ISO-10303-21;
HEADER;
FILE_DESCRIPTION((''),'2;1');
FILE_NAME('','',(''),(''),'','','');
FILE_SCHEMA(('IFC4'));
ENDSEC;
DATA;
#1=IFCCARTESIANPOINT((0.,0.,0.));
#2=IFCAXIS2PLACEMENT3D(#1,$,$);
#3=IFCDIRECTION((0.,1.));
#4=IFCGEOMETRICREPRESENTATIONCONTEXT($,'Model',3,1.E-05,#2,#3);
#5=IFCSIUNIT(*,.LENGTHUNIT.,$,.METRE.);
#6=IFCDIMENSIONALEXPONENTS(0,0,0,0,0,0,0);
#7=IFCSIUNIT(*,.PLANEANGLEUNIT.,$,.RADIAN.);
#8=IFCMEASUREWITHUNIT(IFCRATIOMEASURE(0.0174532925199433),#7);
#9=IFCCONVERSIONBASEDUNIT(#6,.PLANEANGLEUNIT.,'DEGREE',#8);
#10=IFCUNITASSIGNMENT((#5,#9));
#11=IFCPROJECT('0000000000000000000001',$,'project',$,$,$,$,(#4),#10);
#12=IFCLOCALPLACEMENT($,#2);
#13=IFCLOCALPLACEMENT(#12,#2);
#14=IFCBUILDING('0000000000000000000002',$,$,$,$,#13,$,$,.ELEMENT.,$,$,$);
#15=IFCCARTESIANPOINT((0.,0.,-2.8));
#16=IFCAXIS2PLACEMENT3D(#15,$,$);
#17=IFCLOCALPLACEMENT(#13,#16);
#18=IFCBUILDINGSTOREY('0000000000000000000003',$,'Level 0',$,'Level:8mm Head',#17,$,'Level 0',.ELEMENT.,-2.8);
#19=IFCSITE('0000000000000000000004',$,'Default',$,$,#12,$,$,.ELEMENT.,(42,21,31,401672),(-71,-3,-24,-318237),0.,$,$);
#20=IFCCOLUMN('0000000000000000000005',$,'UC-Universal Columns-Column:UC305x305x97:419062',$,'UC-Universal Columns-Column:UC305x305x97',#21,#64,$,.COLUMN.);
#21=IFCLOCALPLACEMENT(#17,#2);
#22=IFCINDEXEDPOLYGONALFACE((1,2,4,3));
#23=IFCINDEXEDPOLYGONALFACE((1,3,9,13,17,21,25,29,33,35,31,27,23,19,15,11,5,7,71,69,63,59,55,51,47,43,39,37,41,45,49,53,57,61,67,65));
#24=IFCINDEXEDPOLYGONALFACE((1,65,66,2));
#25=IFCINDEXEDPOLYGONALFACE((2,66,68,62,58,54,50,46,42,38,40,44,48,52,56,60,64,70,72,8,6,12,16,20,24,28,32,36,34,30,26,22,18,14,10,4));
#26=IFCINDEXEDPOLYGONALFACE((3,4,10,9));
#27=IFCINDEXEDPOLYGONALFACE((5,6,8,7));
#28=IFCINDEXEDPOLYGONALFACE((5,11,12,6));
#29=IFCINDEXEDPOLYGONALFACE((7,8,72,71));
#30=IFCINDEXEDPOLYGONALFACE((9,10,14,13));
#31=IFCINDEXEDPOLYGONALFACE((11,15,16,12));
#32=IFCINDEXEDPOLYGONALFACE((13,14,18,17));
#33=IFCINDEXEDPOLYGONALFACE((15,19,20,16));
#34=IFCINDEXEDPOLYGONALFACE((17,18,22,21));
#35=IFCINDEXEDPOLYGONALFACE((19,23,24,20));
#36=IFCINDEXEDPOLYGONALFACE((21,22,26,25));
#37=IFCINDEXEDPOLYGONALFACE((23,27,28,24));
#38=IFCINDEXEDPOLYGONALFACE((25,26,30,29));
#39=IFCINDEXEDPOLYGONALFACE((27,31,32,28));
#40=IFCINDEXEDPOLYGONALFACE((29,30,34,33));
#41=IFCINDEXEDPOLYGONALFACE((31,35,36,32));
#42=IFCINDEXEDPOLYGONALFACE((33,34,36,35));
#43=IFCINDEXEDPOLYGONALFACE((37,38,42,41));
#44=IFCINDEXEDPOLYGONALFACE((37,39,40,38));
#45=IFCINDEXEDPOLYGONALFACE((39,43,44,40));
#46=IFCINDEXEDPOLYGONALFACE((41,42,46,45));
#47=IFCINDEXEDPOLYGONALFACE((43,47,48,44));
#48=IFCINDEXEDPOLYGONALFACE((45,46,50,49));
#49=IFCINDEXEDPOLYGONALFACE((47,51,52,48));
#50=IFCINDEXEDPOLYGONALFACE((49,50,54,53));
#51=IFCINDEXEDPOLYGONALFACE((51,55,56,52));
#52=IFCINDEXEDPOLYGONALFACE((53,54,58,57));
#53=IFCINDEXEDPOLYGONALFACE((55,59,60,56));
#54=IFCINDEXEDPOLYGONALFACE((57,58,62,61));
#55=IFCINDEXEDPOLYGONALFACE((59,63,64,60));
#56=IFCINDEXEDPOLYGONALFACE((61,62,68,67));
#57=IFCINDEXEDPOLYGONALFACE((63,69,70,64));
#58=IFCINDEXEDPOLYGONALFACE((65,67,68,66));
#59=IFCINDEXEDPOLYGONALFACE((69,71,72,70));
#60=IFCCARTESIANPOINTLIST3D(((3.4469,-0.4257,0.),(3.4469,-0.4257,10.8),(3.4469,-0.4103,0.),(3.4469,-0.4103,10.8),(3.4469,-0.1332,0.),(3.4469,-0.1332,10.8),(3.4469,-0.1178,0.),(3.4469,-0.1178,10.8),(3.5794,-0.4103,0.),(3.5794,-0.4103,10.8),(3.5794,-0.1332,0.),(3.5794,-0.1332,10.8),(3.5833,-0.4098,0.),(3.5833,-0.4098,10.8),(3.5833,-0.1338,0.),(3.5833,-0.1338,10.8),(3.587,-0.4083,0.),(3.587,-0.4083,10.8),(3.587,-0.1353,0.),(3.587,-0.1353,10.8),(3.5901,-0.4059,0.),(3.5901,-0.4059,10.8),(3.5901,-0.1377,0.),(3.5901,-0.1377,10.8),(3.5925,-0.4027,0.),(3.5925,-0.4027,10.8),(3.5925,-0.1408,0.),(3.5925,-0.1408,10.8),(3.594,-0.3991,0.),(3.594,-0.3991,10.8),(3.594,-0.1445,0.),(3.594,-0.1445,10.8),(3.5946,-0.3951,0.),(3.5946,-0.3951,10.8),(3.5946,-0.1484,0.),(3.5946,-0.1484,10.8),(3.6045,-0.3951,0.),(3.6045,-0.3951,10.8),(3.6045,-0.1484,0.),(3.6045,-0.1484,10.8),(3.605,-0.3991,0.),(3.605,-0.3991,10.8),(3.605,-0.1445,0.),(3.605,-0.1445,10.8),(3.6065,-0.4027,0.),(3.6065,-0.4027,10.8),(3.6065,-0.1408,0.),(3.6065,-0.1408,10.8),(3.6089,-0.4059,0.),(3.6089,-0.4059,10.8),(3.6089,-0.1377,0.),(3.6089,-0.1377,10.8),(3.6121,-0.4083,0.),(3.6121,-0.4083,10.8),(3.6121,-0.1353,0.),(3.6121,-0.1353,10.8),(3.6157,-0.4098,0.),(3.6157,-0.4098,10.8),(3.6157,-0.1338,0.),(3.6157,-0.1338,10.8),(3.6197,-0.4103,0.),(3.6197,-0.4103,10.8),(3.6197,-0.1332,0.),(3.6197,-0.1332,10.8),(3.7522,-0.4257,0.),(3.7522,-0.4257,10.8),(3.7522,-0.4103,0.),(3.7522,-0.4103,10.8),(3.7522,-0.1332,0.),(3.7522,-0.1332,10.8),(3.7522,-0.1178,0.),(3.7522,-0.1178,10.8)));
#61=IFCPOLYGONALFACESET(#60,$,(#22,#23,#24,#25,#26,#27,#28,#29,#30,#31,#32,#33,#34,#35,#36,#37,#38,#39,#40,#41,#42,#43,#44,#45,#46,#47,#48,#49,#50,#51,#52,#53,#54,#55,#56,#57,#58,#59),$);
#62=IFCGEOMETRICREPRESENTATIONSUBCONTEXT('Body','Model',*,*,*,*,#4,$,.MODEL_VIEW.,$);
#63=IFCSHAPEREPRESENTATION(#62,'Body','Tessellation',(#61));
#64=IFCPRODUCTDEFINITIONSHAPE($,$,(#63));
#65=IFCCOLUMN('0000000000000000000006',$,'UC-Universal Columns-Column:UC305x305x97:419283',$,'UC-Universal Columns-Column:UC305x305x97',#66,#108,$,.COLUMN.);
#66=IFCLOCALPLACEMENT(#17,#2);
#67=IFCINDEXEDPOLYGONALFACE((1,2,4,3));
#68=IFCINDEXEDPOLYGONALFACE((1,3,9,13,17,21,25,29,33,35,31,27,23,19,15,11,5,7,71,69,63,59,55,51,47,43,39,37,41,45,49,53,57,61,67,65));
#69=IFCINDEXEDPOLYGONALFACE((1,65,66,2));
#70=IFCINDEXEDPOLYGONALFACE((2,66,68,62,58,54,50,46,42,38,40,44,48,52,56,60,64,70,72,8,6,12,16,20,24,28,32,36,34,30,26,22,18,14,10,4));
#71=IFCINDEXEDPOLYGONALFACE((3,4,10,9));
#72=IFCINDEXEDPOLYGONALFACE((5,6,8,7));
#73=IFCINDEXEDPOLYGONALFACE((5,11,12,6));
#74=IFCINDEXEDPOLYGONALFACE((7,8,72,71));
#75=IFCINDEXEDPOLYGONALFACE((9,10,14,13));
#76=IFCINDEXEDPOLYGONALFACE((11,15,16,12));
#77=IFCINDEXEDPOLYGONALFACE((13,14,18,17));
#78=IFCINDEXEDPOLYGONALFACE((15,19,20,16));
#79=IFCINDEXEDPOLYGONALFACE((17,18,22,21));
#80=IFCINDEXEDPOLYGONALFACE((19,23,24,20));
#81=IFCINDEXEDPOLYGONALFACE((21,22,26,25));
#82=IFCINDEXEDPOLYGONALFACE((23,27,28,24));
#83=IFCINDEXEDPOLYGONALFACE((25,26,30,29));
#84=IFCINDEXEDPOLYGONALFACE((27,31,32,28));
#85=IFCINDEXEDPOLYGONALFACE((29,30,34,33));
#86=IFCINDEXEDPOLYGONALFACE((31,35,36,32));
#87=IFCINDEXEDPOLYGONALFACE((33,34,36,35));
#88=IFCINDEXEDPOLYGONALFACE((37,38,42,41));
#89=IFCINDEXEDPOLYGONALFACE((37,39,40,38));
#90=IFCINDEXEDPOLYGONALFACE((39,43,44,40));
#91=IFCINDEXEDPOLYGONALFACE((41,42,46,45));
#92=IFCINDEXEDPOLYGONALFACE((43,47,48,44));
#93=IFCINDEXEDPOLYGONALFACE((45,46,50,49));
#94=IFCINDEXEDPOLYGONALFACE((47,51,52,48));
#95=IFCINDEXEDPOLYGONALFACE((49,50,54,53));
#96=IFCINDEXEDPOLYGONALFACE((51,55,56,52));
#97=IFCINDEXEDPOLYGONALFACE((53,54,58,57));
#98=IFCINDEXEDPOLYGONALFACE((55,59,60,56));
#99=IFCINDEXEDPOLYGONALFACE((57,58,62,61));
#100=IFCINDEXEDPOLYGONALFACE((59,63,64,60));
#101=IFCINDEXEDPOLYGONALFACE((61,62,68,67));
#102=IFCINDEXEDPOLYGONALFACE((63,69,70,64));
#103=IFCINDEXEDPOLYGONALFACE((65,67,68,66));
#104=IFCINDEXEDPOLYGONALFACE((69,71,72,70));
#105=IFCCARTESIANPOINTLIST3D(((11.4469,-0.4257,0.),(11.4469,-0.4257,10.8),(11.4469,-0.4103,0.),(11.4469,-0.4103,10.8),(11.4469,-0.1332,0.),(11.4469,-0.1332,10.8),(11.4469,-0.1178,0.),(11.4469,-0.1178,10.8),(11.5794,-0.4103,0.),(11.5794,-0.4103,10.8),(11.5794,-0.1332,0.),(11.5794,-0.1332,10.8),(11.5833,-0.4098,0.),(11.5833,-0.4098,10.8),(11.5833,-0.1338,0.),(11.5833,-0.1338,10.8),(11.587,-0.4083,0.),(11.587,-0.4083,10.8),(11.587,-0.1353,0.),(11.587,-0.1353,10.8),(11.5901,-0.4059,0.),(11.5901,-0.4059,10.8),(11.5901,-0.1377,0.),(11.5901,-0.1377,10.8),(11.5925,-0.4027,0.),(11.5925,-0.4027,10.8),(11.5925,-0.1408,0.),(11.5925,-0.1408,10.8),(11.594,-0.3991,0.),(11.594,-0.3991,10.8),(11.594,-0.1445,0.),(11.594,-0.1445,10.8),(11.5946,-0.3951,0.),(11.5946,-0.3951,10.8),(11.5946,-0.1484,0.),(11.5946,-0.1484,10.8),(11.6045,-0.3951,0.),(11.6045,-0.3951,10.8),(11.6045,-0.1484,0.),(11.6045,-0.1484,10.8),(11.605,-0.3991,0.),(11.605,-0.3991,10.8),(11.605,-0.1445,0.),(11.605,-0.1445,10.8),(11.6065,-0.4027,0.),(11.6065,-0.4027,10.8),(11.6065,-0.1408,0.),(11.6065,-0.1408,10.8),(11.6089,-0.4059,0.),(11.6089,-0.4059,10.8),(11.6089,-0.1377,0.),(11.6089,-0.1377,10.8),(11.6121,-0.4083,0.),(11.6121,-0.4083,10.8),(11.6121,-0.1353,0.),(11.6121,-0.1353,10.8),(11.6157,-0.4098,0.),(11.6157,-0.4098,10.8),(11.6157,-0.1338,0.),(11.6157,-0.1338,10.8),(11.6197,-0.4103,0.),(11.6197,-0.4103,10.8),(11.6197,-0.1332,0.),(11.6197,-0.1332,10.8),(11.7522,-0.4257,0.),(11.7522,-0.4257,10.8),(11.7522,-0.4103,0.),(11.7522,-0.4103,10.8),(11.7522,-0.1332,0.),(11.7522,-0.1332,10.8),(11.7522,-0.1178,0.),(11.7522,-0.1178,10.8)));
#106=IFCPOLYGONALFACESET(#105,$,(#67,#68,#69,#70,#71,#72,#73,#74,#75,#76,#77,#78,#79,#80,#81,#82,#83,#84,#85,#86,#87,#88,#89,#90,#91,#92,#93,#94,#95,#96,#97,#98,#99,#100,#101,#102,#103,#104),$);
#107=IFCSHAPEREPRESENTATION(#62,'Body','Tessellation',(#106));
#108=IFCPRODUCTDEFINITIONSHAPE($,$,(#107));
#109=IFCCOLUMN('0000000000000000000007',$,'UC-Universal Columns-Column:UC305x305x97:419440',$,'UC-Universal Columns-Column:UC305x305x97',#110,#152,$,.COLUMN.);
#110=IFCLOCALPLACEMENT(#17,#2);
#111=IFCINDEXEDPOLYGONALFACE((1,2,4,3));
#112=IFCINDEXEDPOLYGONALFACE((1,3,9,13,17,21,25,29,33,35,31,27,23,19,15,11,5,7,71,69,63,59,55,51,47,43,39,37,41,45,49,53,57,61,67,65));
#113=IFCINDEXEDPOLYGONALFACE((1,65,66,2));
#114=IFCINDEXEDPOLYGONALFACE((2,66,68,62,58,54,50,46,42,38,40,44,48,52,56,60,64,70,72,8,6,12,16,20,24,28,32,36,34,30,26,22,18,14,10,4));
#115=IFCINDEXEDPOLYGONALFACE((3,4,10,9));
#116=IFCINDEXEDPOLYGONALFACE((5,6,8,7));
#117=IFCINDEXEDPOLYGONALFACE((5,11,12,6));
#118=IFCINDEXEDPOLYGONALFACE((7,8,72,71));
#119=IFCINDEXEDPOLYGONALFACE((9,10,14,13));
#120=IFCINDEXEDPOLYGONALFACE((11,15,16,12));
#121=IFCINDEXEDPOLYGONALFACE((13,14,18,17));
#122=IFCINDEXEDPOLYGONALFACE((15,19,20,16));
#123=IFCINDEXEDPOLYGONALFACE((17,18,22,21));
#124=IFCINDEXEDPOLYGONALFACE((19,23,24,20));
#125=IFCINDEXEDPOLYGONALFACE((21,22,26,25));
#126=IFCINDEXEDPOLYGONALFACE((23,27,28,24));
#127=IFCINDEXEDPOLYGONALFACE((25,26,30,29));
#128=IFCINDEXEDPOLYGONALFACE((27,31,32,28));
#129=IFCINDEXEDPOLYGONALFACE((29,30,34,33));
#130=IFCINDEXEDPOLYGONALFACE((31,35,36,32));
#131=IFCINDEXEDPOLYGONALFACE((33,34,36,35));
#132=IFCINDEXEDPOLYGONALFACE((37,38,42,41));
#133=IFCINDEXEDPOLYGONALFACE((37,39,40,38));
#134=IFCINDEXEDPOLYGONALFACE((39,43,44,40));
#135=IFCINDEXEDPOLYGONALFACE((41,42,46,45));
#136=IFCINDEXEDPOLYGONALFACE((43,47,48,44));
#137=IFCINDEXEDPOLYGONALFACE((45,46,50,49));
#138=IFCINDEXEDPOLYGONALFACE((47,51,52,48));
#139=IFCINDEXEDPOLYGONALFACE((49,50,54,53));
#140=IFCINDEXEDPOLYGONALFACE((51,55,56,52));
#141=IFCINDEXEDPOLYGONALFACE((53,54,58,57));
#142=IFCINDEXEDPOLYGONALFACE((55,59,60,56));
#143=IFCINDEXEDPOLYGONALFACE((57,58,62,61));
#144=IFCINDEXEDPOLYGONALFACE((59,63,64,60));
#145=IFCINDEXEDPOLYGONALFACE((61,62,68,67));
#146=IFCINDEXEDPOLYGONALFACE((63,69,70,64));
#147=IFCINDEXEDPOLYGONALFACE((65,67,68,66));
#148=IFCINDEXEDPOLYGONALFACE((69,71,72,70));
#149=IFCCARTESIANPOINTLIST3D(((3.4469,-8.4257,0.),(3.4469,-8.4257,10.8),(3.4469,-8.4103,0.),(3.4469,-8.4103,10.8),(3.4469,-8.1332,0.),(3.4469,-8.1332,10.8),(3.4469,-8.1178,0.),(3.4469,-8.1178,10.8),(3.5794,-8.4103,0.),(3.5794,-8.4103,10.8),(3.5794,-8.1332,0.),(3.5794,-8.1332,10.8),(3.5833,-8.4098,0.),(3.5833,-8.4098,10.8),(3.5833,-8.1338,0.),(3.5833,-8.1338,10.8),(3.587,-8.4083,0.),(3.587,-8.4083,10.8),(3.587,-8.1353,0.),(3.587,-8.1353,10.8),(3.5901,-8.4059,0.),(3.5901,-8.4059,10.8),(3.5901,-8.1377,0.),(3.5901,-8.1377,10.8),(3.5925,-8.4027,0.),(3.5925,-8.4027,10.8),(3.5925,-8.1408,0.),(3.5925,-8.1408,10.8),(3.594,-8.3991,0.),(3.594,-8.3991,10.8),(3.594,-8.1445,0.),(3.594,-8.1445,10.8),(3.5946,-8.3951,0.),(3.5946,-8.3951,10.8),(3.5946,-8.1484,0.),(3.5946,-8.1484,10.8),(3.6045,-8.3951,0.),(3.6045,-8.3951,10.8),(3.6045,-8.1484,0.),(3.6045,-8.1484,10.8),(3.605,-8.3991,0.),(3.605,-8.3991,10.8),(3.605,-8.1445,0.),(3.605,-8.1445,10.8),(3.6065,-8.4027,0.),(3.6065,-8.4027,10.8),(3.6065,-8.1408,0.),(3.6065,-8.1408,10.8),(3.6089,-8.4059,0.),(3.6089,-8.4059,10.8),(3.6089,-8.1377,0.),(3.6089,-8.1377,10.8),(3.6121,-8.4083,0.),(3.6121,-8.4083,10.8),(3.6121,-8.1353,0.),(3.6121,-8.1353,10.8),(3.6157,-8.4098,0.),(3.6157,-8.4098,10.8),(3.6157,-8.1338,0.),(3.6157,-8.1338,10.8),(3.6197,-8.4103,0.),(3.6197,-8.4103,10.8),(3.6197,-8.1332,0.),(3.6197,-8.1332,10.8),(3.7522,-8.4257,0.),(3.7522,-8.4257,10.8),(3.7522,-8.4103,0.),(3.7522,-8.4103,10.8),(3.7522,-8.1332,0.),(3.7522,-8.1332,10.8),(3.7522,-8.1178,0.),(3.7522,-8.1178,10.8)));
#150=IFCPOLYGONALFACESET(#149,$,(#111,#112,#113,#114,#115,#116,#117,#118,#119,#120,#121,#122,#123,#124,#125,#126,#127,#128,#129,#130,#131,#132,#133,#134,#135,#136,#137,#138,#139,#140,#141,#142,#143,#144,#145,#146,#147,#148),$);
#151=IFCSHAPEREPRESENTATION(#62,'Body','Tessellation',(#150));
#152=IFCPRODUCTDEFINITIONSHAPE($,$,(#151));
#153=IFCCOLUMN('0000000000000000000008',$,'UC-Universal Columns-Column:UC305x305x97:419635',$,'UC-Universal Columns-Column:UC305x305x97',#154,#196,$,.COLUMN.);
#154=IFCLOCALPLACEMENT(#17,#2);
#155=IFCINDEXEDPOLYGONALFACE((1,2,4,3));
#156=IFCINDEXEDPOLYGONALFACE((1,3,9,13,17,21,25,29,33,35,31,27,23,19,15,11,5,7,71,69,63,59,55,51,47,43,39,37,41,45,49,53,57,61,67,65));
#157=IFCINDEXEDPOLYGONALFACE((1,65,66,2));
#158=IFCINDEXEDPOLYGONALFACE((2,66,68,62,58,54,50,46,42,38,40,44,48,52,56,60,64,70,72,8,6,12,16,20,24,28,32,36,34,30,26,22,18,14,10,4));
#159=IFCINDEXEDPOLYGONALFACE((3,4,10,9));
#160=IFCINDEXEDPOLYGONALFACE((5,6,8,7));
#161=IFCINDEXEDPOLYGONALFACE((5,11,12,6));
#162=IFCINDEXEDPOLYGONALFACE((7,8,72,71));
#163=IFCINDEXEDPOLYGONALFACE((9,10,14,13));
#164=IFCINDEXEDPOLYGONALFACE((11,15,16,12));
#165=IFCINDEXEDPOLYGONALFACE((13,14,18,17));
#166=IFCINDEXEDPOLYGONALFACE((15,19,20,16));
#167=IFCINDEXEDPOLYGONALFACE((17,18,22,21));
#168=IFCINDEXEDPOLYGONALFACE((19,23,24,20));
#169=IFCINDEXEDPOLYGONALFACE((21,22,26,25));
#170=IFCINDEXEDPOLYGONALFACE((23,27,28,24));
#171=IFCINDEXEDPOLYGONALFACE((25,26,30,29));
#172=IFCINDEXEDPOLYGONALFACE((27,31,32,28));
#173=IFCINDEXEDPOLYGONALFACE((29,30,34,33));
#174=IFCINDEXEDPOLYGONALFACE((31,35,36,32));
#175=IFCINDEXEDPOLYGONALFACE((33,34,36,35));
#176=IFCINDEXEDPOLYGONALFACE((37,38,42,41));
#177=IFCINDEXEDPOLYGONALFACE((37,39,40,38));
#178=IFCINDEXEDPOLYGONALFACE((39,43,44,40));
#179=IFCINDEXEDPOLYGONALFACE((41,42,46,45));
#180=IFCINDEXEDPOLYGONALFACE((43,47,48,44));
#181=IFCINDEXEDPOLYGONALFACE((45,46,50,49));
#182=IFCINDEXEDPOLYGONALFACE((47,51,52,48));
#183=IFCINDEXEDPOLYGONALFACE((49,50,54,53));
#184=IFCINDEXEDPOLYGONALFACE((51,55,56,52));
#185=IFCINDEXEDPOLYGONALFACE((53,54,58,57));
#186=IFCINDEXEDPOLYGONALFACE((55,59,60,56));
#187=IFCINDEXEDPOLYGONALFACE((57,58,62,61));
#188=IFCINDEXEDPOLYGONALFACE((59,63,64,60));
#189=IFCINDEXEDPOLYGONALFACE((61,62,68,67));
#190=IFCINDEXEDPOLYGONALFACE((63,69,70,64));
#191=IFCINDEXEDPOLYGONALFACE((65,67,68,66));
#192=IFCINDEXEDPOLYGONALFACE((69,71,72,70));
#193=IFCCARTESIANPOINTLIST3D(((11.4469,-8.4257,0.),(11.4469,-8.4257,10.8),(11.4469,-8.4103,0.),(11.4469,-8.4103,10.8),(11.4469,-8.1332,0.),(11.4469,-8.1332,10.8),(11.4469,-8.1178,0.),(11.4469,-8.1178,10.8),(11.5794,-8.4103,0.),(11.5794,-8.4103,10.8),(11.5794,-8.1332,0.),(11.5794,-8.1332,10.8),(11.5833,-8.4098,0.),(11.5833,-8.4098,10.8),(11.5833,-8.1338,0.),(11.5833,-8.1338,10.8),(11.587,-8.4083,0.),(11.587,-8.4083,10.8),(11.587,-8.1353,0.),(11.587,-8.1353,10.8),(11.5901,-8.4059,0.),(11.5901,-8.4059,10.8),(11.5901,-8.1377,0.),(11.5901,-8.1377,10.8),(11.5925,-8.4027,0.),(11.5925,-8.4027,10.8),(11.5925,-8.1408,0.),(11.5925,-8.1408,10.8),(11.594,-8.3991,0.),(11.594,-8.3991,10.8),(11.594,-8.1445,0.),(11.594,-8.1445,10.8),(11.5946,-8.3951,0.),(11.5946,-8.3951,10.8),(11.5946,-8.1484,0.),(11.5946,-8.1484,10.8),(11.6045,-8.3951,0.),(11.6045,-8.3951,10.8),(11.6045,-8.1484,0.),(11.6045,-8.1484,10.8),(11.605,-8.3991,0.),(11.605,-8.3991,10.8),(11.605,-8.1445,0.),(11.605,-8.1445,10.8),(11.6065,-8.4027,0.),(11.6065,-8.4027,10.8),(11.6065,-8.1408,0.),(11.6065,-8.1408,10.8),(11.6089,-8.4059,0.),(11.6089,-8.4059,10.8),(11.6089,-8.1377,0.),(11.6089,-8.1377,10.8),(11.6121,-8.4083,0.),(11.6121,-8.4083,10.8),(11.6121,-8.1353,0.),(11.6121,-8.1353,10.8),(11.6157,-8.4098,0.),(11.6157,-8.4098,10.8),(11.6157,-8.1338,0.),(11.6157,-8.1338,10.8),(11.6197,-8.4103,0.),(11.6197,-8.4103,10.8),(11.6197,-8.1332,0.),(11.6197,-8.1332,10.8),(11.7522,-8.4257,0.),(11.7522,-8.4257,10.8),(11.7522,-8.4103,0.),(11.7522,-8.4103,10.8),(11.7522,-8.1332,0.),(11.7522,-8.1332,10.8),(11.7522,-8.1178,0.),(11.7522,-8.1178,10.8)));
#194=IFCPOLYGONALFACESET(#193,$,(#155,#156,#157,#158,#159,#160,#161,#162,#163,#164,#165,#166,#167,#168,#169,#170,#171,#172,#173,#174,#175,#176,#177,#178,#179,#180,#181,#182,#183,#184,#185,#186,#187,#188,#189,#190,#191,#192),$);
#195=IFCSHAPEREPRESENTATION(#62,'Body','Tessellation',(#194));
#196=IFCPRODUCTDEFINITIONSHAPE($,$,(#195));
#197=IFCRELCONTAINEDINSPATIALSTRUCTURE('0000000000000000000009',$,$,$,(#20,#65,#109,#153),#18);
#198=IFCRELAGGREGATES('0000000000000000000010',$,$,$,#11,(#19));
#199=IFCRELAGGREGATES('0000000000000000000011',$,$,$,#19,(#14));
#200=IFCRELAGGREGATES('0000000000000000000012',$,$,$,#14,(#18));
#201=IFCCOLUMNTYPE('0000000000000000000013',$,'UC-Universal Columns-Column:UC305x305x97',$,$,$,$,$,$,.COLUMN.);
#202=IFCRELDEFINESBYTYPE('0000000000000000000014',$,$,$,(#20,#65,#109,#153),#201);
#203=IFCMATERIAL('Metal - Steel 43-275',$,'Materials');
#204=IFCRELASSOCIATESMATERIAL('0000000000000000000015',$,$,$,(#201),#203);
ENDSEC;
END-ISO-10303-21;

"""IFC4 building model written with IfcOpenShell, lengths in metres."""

from ifc_helpers import new_model, entity, si_unit, converted_unit, direction, frame, frame_2d, origin, place, context, subcontext, project, spatial, i_section, extrude, source, transform, mapped, material, material_profile, profile_set, type_object, type_shapes, element, save


model = new_model("IFC4")

# Units and contexts
model_context = context("Model", 3, precision=1e-05, world=origin(), true_north=direction((0.0, 1.0)))
body_context = subcontext(model_context, "Body", "Model", "MODEL_VIEW")
ifc_project = project(units=[si_unit("LENGTHUNIT", "METRE"), converted_unit("PLANEANGLEUNIT", "DEGREE", entity("IfcRatioMeasure", 0.0174532925199433), si_unit("PLANEANGLEUNIT", "RADIAN"), dimensions=[0, 0, 0, 0, 0, 0, 0])], contexts=[model_context])

# Site, building, storey
site_placement = place(None, origin())
site = spatial("IfcSite", under=ifc_project, at=site_placement, Name="Default", CompositionType="ELEMENT", RefLatitude=(42, 21, 31, 401672), RefLongitude=(-71, -3, -24, -318237), RefElevation=0.0)
building_placement = place(site_placement, origin())
building = spatial("IfcBuilding", under=site, at=building_placement, CompositionType="ELEMENT")
storey_placement = place(building_placement, frame((0.0, 0.0, -2.8)))
storey = spatial("IfcBuildingStorey", under=building, at=storey_placement, Name="Level 0", ObjectType="Level:8mm Head", LongName="Level 0", CompositionType="ELEMENT", Elevation=-2.8)

# Columns
ifc_material_1 = material(Name="Metal - Steel 43-275", Category="Materials")
ifc_material_profile = material_profile(ifc_material_1, i_section(OverallWidth=0.3053, OverallDepth=0.3079, WebThickness=0.0099, FlangeThickness=0.0154, FilletRadius=0.0152, at=frame_2d((0.0, 0.0), x_axis=(0.0, 1.0))), Name="UC305x305x97")
ifc_profile_set = profile_set([ifc_material_profile], Name="UC305x305x97")
column_type = type_object("IfcColumnType", Name="UC-Universal Columns-Column:UC305x305x97", PredefinedType="COLUMN", material=ifc_profile_set)
shared_shape = source(origin(), body_context, "Body", "SweptSolid", [
    extrude(i_section(OverallWidth=0.3053, OverallDepth=0.3079, WebThickness=0.0099, FlangeThickness=0.0154, FilletRadius=0.0152, at=frame_2d((0.0, 0.0), x_axis=(0.0, 1.0))), frame((0.0, 0.0, -2.8), z_axis=(0.0, 0.0, 1.0), x_axis=(0.0, -1.0, 0.0)), (0.0, 0.0, 1.0), 10.8),
])
type_shapes(column_type, [shared_shape])
for number, where, name in (
    (1, (3.5995, -0.2718, 2.8), "UC-Universal Columns-Column:UC305x305x97:419062"),
    (2, (11.5995, -0.2718, 2.8), "UC-Universal Columns-Column:UC305x305x97:419283"),
    (3, (3.5995, -8.2718, 2.8), "UC-Universal Columns-Column:UC305x305x97:419440"),
    (4, (11.5995, -8.2718, 2.8), "UC-Universal Columns-Column:UC305x305x97:419635"),
):
    element("IfcColumn", number, at=place(storey_placement, frame(where)), inside=storey, type_object=column_type, Name=name, ObjectType="UC-Universal Columns-Column:UC305x305x97", PredefinedType="COLUMN", context=body_context, shape_type="MappedRepresentation", body=[
        mapped(shared_shape, transform((0.0, 0.0, 0.0), scale=1.0)),
    ])

save(model, "model.ifc")
